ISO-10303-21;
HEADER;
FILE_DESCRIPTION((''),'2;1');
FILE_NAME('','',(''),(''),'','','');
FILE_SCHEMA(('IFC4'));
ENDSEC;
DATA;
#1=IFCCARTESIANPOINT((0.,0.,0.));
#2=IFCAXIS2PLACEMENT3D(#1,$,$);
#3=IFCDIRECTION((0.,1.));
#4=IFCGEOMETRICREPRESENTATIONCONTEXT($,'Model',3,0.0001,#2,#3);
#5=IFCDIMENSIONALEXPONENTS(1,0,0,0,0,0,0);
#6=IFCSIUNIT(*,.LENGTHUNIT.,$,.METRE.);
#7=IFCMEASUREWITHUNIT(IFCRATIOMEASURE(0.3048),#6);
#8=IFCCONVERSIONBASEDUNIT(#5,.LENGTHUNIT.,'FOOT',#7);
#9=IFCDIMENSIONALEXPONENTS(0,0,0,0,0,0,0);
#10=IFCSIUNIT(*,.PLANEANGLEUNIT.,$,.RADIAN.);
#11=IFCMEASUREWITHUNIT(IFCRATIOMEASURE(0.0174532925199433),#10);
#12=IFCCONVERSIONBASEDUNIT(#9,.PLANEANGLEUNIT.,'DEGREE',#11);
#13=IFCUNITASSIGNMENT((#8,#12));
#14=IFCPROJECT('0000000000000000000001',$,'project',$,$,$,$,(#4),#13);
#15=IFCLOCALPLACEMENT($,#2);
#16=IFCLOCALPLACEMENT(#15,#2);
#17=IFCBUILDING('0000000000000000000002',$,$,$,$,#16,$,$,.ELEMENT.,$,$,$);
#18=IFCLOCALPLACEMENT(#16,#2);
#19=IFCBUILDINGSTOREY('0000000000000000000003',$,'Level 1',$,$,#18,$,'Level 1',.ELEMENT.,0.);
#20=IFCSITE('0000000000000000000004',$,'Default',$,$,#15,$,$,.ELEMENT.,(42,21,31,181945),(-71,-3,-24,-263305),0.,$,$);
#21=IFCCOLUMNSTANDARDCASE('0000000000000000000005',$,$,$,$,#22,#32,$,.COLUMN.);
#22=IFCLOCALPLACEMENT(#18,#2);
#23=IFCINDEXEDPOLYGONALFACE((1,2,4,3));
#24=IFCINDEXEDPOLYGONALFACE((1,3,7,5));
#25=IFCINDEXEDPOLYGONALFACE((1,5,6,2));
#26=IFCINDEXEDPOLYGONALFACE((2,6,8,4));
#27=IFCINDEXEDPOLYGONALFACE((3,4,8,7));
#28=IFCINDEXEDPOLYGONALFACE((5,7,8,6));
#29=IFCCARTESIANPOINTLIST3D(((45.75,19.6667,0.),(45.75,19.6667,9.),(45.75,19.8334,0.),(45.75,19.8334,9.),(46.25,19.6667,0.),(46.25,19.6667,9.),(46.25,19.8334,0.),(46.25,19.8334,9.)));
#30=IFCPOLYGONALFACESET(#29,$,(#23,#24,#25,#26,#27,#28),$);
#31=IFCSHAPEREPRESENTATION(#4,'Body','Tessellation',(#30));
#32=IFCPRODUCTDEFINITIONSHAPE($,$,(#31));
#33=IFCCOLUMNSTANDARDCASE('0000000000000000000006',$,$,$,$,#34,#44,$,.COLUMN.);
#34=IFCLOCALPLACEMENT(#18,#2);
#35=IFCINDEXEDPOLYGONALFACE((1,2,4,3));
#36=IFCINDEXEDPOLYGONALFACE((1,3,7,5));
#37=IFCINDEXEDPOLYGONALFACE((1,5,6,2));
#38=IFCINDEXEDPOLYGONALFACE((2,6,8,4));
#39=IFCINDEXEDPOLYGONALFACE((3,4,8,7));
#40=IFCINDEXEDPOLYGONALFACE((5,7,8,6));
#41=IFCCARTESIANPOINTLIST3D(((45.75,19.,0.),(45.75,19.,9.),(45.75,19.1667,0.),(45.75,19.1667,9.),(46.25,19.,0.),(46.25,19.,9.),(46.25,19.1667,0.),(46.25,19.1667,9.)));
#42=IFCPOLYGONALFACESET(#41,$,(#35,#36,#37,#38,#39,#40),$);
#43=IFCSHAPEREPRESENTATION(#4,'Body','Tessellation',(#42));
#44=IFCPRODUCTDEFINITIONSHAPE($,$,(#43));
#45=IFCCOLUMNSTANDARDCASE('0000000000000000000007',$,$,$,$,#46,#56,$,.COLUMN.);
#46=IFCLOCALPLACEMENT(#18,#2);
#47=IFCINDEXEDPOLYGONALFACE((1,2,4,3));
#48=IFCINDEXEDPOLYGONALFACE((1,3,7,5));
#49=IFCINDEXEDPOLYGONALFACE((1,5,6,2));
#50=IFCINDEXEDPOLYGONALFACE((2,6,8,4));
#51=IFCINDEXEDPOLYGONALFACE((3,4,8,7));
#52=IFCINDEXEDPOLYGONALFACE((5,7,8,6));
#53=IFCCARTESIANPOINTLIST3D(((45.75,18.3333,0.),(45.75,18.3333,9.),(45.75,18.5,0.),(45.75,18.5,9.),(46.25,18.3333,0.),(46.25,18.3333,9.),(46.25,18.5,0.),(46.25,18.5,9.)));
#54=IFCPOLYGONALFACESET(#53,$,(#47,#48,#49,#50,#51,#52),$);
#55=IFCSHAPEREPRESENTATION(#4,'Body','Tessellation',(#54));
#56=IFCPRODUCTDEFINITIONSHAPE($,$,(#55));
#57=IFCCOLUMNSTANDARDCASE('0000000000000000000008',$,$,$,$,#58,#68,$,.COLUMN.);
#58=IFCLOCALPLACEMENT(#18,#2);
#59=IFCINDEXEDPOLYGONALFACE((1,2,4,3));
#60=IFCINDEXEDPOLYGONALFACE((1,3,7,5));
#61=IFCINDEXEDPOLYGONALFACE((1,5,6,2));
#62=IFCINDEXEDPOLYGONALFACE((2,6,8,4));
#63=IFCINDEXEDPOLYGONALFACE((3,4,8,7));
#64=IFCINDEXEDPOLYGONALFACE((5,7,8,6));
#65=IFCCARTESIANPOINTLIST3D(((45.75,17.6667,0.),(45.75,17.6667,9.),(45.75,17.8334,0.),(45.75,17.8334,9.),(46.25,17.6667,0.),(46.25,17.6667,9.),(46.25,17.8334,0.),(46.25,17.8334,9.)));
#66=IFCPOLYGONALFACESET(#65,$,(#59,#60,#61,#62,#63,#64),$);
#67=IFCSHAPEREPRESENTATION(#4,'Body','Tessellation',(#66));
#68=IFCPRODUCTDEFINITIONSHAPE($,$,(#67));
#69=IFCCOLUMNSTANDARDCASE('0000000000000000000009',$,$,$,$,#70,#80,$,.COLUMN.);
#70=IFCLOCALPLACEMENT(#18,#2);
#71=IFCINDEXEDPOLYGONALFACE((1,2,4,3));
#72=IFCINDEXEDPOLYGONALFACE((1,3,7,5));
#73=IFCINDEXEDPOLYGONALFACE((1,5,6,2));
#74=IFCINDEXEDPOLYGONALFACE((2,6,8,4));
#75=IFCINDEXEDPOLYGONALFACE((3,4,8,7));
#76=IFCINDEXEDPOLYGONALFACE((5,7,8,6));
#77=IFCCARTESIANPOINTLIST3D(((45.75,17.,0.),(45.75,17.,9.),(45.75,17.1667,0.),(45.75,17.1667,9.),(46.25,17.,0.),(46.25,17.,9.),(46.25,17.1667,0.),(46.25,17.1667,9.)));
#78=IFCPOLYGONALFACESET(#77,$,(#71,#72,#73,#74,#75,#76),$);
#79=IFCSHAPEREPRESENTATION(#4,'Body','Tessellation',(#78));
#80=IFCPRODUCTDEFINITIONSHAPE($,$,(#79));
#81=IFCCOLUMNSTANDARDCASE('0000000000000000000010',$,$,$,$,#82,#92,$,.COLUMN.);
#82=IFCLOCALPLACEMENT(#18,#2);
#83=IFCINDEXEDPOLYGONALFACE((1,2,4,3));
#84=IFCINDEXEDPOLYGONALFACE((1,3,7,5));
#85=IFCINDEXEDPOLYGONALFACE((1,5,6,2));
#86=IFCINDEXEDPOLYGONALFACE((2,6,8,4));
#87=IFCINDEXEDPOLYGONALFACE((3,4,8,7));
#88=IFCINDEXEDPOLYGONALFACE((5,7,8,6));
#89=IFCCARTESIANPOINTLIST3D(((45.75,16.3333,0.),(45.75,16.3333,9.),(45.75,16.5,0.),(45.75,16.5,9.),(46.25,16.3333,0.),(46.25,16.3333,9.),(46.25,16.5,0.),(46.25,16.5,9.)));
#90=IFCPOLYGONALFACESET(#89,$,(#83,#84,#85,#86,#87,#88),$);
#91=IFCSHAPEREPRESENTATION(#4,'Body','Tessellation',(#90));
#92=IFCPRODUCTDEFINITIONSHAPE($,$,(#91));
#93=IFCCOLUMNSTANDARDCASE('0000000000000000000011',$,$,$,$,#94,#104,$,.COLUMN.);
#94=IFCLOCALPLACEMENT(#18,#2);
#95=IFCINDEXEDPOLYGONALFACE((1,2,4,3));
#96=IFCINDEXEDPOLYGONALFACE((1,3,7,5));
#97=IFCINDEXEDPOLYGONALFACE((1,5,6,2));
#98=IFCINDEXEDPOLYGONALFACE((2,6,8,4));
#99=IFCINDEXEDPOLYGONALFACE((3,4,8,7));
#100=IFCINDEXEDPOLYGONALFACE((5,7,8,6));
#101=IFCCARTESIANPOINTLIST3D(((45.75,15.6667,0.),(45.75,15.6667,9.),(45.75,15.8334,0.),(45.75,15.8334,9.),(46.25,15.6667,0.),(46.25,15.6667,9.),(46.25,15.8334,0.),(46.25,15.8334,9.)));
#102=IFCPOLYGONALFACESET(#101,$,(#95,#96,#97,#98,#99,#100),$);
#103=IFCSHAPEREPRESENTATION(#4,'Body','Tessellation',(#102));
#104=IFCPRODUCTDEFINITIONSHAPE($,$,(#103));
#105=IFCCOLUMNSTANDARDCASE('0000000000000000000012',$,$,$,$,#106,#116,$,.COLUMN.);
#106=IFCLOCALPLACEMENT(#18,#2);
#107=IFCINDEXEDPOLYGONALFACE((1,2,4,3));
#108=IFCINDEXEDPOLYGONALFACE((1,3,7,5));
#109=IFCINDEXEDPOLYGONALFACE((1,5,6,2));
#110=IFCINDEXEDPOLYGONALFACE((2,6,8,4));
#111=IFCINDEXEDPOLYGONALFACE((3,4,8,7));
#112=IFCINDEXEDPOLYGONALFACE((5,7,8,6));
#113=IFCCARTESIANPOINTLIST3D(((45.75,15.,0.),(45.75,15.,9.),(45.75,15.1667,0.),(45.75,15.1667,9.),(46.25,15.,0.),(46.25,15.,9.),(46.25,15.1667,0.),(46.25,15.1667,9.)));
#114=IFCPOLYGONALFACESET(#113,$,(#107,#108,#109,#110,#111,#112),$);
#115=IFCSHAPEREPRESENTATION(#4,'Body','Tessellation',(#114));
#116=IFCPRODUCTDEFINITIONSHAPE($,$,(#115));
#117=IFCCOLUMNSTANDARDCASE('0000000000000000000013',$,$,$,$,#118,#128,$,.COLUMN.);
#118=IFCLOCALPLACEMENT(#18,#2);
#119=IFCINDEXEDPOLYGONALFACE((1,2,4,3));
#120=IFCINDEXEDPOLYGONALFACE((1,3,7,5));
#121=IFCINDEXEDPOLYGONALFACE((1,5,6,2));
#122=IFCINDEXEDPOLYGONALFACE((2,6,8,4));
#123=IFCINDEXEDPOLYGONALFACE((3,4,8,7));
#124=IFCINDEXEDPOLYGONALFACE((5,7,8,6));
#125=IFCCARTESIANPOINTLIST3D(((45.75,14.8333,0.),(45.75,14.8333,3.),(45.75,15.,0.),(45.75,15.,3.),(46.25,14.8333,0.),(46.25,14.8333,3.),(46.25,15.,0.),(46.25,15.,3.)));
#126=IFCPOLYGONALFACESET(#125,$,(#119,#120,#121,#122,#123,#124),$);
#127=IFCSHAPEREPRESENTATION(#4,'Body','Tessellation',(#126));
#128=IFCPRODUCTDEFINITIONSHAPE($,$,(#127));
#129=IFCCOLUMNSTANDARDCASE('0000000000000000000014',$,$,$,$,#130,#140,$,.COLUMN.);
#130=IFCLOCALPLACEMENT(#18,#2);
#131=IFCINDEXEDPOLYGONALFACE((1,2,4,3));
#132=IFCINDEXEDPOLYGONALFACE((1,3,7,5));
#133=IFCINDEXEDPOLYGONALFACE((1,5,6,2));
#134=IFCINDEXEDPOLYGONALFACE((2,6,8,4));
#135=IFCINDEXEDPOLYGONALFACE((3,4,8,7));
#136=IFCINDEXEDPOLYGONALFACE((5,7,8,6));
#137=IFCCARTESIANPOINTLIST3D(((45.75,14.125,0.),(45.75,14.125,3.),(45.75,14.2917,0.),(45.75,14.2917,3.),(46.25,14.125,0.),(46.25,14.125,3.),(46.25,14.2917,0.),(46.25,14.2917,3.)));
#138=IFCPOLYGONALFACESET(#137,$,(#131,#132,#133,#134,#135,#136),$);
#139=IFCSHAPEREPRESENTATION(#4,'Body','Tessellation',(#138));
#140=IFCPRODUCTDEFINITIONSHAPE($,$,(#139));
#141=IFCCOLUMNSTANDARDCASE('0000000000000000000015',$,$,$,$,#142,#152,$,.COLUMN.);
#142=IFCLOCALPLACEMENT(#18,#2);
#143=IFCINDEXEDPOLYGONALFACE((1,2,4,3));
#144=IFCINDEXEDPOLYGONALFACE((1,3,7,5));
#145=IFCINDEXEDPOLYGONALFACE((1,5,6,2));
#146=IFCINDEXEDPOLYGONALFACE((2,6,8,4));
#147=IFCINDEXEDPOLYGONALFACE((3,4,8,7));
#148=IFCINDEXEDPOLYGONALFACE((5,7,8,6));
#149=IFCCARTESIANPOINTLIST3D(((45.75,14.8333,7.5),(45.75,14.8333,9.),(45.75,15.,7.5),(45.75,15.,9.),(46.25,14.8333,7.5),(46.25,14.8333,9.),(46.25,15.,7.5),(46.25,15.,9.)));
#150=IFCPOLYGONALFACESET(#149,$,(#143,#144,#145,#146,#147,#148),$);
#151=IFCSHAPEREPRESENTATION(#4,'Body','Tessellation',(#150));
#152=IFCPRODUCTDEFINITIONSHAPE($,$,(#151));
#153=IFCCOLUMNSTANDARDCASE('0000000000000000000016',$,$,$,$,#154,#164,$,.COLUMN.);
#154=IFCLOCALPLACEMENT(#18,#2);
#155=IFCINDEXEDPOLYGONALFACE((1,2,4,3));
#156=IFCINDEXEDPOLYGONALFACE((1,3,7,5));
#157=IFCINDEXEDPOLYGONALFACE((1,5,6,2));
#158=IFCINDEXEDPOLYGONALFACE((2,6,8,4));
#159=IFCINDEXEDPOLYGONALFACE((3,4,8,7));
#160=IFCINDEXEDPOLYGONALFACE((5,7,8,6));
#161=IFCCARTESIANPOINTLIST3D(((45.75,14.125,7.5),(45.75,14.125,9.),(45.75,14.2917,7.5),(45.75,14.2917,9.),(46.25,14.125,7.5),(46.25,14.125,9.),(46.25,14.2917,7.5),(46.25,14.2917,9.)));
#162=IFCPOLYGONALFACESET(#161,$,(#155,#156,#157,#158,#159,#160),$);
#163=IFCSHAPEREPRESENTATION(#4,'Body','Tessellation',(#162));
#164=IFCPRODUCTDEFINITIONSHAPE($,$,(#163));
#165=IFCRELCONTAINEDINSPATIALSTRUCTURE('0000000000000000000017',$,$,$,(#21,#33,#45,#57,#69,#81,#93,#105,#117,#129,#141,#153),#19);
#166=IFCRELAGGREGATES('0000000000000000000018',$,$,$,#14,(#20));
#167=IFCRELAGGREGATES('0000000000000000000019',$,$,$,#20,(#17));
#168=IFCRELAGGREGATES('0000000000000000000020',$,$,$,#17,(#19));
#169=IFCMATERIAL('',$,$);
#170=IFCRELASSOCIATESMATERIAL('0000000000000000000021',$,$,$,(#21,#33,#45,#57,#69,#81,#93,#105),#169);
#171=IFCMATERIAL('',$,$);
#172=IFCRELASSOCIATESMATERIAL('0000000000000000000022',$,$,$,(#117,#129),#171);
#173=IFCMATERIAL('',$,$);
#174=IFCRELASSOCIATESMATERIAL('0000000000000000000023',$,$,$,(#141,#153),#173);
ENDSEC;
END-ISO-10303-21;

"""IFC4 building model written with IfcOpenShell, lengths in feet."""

from ifc_helpers import new_model, entity, si_unit, converted_unit, direction, frame, origin, place, context, project, spatial, rectangle, extrude, material, element, save


model = new_model("IFC4")

# Units and contexts
model_context = context("Model", 3, precision=0.0001, world=origin(), true_north=direction((0.0, 1.0)))
ifc_project = project(units=[converted_unit("LENGTHUNIT", "FOOT", entity("IfcRatioMeasure", 0.3048), si_unit("LENGTHUNIT", "METRE"), dimensions=[1, 0, 0, 0, 0, 0, 0]), converted_unit("PLANEANGLEUNIT", "DEGREE", entity("IfcRatioMeasure", 0.0174532925199433), si_unit("PLANEANGLEUNIT", "RADIAN"), dimensions=[0, 0, 0, 0, 0, 0, 0])], contexts=[model_context])

# Site, building, storey
site_placement = place(None, origin())
site = spatial("IfcSite", under=ifc_project, at=site_placement, Name="Default", CompositionType="ELEMENT", RefLatitude=(42, 21, 31, 181945), RefLongitude=(-71, -3, -24, -263305), RefElevation=0.0)
building_placement = place(site_placement, origin())
building = spatial("IfcBuilding", under=site, at=building_placement, CompositionType="ELEMENT")
storey_placement = place(building_placement, origin())
storey = spatial("IfcBuildingStorey", under=building, at=storey_placement, Name="Level 1", LongName="Level 1", CompositionType="ELEMENT", Elevation=0.0)

# Columns
ifc_material_1 = material(Name="")
placement_1 = place(storey_placement, frame((46.0, 46.25, 0.0), z_axis=(0.0, 0.0, 1.0), x_axis=(0.0, -1.0, 0.0)))
for number, where, z_axis, x_axis in (
    (1, (26.5, 0.0, 0.0), (0.0, 0.0, 1.0), (1.0, 0.0, 0.0)),
    (2, (27.1667, 0.0, 0.0), (0.0, 0.0, 1.0), (1.0, 0.0, 0.0)),
    (3, (27.8333, 0.0, 0.0), (0.0, 0.0, 1.0), (1.0, 0.0, 0.0)),
    (4, (28.5, 0.0, 0.0), (0.0, 0.0, 1.0), (1.0, 0.0, 0.0)),
    (5, (29.1667, 0.0, 0.0), (0.0, 0.0, 1.0), (1.0, 0.0, 0.0)),
    (6, (29.8333, 0.0, 0.0), (0.0, 0.0, 1.0), (1.0, 0.0, 0.0)),
    (7, (30.5, 0.0, 0.0), (0.0, 0.0, 1.0), (1.0, 0.0, 0.0)),
    (8, (31.1667, 0.0, 0.0), (0.0, 0.0, 1.0), (1.0, 0.0, 0.0)),
):
    element("IfcColumnStandardCase", number, at=place(placement_1, frame(where, z_axis=z_axis, x_axis=x_axis)), inside=storey, material=ifc_material_1, PredefinedType="COLUMN", context=model_context, shape_type="SweptSolid", body=[
        extrude(rectangle(XDim=0.1667, YDim=0.5), origin(), (0.0, 0.0, 1.0), 9.0),
    ])
ifc_material_2 = material(Name="")
for number, where, z_axis, x_axis in (
    (9, (31.3334, 0.0, 0.0), (0.0, 0.0, 1.0), (1.0, 0.0, 0.0)),
    (10, (32.0417, 0.0, 0.0), (0.0, 0.0, 1.0), (1.0, 0.0, 0.0)),
):
    element("IfcColumnStandardCase", number, at=place(placement_1, frame(where, z_axis=z_axis, x_axis=x_axis)), inside=storey, material=ifc_material_2, PredefinedType="COLUMN", context=model_context, shape_type="SweptSolid", body=[
        extrude(rectangle(XDim=0.1667, YDim=0.5), origin(), (0.0, 0.0, 1.0), 3.0),
    ])
ifc_material_3 = material(Name="")
for number, where, z_axis, x_axis in (
    (11, (31.3334, 0.0, 7.5), (0.0, 0.0, 1.0), (1.0, 0.0, 0.0)),
    (12, (32.0417, 0.0, 7.5), (0.0, 0.0, 1.0), (1.0, 0.0, 0.0)),
):
    element("IfcColumnStandardCase", number, at=place(placement_1, frame(where, z_axis=z_axis, x_axis=x_axis)), inside=storey, material=ifc_material_3, PredefinedType="COLUMN", context=model_context, shape_type="SweptSolid", body=[
        extrude(rectangle(XDim=0.1667, YDim=0.5), origin(), (0.0, 0.0, 1.0), 1.5),
    ])

save(model, "model.ifc")
